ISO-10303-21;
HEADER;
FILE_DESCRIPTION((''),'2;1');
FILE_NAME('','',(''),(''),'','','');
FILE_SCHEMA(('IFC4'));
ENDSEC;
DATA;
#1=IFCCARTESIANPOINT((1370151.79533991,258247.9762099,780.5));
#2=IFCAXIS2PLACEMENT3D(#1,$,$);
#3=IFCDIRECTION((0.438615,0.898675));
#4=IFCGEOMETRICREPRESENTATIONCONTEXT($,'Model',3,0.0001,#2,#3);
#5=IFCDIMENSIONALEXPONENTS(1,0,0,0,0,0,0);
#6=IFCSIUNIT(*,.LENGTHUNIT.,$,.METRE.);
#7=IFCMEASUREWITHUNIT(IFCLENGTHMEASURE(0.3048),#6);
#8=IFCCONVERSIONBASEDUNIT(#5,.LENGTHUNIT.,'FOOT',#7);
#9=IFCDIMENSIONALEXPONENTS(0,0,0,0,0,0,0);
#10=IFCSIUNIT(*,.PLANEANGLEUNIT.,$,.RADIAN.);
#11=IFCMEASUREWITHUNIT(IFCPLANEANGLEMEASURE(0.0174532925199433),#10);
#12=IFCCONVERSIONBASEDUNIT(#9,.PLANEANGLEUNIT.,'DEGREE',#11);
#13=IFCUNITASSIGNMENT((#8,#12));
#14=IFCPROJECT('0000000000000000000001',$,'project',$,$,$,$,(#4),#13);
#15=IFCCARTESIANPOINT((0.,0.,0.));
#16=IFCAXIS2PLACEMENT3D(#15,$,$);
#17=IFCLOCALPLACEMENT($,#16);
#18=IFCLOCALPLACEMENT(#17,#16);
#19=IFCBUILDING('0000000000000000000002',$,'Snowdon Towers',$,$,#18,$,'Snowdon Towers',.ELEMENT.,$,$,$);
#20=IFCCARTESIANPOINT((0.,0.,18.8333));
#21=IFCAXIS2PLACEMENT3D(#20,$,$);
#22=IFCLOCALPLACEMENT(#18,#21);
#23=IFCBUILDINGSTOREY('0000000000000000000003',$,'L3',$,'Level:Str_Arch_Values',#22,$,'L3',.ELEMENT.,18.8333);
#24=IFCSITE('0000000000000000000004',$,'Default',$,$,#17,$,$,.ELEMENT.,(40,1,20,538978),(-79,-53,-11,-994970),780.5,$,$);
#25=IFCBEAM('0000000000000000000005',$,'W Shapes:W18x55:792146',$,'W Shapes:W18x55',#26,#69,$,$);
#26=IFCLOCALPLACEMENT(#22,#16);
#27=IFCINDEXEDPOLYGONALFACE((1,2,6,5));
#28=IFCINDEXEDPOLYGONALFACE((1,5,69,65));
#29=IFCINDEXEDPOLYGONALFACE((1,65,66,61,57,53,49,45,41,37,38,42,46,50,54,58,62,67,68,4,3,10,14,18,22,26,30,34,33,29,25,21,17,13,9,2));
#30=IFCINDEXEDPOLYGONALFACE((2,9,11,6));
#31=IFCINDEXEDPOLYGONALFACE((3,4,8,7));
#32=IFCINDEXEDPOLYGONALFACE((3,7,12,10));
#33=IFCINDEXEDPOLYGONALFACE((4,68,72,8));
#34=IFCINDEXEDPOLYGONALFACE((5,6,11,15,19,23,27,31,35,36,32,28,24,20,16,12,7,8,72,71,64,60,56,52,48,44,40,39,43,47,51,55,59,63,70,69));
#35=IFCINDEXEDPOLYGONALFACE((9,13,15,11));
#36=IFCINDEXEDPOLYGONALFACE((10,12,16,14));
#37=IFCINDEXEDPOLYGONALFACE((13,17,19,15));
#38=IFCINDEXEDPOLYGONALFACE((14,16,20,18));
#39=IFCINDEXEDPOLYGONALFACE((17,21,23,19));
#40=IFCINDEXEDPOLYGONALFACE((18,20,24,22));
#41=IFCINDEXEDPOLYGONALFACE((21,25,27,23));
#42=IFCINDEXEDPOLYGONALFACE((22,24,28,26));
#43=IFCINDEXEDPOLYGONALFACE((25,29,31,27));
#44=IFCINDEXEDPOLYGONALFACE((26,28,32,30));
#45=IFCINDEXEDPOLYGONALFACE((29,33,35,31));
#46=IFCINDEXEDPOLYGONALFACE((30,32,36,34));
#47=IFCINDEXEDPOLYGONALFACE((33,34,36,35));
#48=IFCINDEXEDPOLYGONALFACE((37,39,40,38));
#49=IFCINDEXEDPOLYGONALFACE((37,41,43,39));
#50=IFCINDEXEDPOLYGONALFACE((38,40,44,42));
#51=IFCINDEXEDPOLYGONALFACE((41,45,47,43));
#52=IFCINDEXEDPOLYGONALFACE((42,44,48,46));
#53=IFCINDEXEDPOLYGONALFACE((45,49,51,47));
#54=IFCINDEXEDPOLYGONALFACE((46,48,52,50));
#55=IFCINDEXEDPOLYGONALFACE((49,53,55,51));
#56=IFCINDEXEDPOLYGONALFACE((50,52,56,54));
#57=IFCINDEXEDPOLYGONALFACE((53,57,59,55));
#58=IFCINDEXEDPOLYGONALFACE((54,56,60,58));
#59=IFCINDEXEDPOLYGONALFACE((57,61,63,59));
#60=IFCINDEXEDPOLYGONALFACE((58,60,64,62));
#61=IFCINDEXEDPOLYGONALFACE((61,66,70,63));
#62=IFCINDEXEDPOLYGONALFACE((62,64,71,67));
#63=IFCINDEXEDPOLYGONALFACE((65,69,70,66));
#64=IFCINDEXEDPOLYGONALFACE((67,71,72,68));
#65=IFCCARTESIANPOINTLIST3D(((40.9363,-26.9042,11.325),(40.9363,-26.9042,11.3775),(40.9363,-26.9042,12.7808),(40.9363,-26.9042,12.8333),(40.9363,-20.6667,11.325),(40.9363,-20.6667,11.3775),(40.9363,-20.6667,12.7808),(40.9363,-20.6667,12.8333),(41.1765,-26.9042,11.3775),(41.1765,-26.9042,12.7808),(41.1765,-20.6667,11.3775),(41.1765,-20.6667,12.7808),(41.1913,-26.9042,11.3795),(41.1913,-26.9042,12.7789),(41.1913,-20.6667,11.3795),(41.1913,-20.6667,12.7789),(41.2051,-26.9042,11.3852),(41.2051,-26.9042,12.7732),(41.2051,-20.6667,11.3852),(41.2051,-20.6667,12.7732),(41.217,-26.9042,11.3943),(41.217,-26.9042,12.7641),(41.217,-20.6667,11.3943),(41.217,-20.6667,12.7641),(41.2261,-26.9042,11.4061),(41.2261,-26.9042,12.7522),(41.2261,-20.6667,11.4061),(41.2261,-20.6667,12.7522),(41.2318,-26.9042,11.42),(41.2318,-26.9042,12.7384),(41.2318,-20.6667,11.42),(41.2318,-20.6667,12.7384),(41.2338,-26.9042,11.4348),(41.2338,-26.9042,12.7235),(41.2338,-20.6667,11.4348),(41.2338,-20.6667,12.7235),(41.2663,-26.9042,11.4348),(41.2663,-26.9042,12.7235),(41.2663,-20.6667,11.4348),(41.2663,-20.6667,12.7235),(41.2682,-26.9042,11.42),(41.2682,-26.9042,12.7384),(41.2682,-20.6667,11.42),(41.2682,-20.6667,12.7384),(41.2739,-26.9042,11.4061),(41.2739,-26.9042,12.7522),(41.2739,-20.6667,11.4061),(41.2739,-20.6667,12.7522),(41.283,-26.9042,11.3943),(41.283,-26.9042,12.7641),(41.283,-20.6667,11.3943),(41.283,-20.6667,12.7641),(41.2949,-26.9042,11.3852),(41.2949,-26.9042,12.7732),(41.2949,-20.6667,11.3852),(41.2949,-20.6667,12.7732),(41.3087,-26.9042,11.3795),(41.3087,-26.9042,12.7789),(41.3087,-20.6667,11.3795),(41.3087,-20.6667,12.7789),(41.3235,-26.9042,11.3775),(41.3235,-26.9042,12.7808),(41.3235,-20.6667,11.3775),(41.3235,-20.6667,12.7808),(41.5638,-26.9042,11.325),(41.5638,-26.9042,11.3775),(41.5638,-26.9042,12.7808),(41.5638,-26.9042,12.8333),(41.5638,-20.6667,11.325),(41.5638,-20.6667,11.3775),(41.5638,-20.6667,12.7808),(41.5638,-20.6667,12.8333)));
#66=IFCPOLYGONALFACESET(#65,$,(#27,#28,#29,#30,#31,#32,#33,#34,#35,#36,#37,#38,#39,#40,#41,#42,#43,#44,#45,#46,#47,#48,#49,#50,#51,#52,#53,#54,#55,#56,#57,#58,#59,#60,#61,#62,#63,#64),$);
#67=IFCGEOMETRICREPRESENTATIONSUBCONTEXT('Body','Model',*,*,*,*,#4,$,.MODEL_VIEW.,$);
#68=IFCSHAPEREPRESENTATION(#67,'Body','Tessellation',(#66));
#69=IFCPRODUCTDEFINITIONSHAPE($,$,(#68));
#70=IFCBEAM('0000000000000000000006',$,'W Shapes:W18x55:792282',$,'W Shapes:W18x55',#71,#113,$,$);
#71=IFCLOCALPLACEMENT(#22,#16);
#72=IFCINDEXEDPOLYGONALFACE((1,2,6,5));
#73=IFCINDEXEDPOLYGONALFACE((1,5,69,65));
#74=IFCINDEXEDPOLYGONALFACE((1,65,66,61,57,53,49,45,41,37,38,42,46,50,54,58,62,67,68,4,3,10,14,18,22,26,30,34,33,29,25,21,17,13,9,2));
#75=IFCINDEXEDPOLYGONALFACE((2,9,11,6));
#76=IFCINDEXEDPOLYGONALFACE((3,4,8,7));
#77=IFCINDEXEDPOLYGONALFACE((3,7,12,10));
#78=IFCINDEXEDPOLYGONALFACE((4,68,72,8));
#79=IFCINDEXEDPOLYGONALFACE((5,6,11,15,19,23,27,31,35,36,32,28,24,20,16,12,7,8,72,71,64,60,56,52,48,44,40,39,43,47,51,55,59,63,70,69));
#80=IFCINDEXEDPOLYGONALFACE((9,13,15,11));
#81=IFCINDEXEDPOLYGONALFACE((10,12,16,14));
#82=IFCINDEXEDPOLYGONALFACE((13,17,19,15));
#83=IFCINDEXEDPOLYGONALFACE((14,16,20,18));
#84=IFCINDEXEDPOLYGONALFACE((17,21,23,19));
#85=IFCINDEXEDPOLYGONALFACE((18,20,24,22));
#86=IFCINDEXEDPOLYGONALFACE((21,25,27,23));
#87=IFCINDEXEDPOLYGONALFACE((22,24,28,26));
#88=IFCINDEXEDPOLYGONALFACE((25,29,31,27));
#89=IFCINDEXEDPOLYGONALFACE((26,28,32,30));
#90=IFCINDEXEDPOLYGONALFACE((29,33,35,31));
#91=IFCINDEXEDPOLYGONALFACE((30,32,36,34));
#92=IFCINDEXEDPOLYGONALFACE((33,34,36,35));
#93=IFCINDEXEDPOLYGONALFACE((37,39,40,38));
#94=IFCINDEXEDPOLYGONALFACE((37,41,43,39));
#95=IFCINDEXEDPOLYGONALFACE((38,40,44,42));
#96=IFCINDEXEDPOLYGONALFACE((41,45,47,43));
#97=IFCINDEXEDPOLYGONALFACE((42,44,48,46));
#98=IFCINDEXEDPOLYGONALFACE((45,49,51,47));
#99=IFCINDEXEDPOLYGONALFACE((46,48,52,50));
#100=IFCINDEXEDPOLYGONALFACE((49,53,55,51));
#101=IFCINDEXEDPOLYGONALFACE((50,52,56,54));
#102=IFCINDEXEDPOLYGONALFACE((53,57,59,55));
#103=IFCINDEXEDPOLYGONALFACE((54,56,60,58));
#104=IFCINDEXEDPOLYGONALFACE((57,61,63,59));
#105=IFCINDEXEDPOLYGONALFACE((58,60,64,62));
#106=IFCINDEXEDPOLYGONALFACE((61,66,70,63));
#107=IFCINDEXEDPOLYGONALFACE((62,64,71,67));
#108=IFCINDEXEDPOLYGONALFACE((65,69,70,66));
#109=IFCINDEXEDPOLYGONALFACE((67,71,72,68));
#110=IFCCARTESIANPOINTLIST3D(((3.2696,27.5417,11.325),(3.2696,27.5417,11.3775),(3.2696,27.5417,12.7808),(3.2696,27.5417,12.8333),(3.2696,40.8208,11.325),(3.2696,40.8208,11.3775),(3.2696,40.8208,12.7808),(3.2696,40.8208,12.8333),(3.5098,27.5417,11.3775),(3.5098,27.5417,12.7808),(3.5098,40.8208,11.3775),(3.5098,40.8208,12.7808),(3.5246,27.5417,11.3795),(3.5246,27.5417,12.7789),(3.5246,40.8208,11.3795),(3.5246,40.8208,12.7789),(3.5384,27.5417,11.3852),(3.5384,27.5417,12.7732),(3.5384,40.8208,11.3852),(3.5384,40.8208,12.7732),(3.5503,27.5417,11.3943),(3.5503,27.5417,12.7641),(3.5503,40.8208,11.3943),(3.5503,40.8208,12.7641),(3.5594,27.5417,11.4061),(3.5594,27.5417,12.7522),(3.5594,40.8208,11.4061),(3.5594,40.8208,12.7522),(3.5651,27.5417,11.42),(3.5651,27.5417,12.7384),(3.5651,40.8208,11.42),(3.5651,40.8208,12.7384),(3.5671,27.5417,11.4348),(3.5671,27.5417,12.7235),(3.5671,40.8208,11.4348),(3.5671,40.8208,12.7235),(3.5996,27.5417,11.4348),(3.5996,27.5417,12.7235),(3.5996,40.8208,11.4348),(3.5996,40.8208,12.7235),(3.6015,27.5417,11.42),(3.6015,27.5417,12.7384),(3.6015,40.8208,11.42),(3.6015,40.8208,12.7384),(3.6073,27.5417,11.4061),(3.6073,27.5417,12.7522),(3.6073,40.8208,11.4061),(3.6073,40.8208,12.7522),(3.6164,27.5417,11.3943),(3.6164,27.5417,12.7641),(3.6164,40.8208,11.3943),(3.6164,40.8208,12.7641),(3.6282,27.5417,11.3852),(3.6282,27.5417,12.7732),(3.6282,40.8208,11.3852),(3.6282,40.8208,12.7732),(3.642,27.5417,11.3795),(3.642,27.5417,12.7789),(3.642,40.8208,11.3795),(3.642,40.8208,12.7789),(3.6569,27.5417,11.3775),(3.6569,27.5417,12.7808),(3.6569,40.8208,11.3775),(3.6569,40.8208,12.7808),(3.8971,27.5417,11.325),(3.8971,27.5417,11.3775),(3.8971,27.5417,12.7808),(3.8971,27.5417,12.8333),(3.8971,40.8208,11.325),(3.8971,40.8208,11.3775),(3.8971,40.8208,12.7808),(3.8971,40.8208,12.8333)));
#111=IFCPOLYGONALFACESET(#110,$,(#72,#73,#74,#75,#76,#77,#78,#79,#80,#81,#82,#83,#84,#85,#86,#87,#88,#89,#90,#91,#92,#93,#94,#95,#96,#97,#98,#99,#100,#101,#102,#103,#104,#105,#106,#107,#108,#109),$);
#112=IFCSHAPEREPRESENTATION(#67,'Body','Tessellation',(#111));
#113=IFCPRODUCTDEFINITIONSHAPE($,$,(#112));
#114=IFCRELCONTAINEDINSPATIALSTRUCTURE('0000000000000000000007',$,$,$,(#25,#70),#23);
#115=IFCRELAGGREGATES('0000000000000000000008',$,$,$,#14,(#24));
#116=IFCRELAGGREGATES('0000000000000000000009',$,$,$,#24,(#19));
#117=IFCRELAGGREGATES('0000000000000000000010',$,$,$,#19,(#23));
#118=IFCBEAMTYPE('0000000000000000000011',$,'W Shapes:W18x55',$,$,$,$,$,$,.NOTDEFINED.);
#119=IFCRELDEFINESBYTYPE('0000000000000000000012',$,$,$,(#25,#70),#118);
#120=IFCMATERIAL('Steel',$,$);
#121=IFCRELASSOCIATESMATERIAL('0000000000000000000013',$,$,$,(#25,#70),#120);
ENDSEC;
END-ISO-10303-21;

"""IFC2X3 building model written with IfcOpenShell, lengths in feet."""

from ifc_helpers import new_model, entity, si_unit, converted_unit, direction, frame, frame_2d, origin, place, context, subcontext, project, spatial, i_section, extrude, material, type_object, element, save


model = new_model("IFC2X3")

# Units and contexts
model_context = context("Model", 3, precision=0.0001, world=frame((1370151.79533991, 258247.9762099, 780.5)), true_north=direction((0.438615, 0.898675)))
body_context = subcontext(model_context, "Body", "Model", "MODEL_VIEW")
ifc_project = project(units=[converted_unit("LENGTHUNIT", "FOOT", entity("IfcLengthMeasure", 0.3048), si_unit("LENGTHUNIT", "METRE"), dimensions=[1, 0, 0, 0, 0, 0, 0]), converted_unit("PLANEANGLEUNIT", "DEGREE", entity("IfcPlaneAngleMeasure", 0.0174532925199433), si_unit("PLANEANGLEUNIT", "RADIAN"), dimensions=[0, 0, 0, 0, 0, 0, 0])], contexts=[model_context])

# Site, building, storey
site_placement = place(None, origin())
site = spatial("IfcSite", under=ifc_project, at=site_placement, Name="Default", CompositionType="ELEMENT", RefLatitude=(40, 1, 20, 538978), RefLongitude=(-79, -53, -11, -994970), RefElevation=780.5)
building_placement = place(site_placement, origin())
building = spatial("IfcBuilding", under=site, at=building_placement, Name="Snowdon Towers", LongName="Snowdon Towers", CompositionType="ELEMENT")
storey_placement = place(building_placement, frame((0.0, 0.0, 18.8333)))
storey = spatial("IfcBuildingStorey", under=building, at=storey_placement, Name="L3", ObjectType="Level:Str_Arch_Values", LongName="L3", CompositionType="ELEMENT", Elevation=18.8333)

# Beams
ifc_material = material(Name="Steel")
beam_type_1 = type_object("IfcBeamType", Name="W Shapes:W18x55", PredefinedType="NOTDEFINED")
beam_1_placement = place(storey_placement, frame((41.25, -20.125, 12.8333), z_axis=(0.0, 0.0, 1.0), x_axis=(0.0, -1.0, 0.0)))
element("IfcBeam", 1, at=beam_1_placement, inside=storey, type_object=beam_type_1, material=ifc_material, Name="W Shapes:W18x55:792146", ObjectType="W Shapes:W18x55", context=body_context, shape_type="SweptSolid", body=[
    extrude(i_section(OverallWidth=0.6275, OverallDepth=1.5083, WebThickness=0.0325, FlangeThickness=0.0525, FilletRadius=0.0573, at=frame_2d((0.0, 0.0), x_axis=(0.0, 1.0))), frame((0.5417, 0.0, -0.7542), z_axis=(1.0, 0.0, 0.0), x_axis=(0.0, 0.0, -1.0)), (0.0, 0.0, 1.0), 6.2375),
])
beam_2_placement = place(storey_placement, frame((3.5833, 41.625, 12.8333), z_axis=(0.0, 0.0, 1.0), x_axis=(0.0, -1.0, 0.0)))
element("IfcBeam", 2, at=beam_2_placement, inside=storey, type_object=beam_type_1, material=ifc_material, Name="W Shapes:W18x55:792282", ObjectType="W Shapes:W18x55", context=body_context, shape_type="SweptSolid", body=[
    extrude(i_section(OverallWidth=0.6275, OverallDepth=1.5083, WebThickness=0.0325, FlangeThickness=0.0525, FilletRadius=0.0573, at=frame_2d((0.0, 0.0), x_axis=(0.0, 1.0))), frame((0.8042, 0.0, -0.7542), z_axis=(1.0, 0.0, 0.0), x_axis=(0.0, 0.0, -1.0)), (0.0, 0.0, 1.0), 13.2792),
])

save(model, "model.ifc")
